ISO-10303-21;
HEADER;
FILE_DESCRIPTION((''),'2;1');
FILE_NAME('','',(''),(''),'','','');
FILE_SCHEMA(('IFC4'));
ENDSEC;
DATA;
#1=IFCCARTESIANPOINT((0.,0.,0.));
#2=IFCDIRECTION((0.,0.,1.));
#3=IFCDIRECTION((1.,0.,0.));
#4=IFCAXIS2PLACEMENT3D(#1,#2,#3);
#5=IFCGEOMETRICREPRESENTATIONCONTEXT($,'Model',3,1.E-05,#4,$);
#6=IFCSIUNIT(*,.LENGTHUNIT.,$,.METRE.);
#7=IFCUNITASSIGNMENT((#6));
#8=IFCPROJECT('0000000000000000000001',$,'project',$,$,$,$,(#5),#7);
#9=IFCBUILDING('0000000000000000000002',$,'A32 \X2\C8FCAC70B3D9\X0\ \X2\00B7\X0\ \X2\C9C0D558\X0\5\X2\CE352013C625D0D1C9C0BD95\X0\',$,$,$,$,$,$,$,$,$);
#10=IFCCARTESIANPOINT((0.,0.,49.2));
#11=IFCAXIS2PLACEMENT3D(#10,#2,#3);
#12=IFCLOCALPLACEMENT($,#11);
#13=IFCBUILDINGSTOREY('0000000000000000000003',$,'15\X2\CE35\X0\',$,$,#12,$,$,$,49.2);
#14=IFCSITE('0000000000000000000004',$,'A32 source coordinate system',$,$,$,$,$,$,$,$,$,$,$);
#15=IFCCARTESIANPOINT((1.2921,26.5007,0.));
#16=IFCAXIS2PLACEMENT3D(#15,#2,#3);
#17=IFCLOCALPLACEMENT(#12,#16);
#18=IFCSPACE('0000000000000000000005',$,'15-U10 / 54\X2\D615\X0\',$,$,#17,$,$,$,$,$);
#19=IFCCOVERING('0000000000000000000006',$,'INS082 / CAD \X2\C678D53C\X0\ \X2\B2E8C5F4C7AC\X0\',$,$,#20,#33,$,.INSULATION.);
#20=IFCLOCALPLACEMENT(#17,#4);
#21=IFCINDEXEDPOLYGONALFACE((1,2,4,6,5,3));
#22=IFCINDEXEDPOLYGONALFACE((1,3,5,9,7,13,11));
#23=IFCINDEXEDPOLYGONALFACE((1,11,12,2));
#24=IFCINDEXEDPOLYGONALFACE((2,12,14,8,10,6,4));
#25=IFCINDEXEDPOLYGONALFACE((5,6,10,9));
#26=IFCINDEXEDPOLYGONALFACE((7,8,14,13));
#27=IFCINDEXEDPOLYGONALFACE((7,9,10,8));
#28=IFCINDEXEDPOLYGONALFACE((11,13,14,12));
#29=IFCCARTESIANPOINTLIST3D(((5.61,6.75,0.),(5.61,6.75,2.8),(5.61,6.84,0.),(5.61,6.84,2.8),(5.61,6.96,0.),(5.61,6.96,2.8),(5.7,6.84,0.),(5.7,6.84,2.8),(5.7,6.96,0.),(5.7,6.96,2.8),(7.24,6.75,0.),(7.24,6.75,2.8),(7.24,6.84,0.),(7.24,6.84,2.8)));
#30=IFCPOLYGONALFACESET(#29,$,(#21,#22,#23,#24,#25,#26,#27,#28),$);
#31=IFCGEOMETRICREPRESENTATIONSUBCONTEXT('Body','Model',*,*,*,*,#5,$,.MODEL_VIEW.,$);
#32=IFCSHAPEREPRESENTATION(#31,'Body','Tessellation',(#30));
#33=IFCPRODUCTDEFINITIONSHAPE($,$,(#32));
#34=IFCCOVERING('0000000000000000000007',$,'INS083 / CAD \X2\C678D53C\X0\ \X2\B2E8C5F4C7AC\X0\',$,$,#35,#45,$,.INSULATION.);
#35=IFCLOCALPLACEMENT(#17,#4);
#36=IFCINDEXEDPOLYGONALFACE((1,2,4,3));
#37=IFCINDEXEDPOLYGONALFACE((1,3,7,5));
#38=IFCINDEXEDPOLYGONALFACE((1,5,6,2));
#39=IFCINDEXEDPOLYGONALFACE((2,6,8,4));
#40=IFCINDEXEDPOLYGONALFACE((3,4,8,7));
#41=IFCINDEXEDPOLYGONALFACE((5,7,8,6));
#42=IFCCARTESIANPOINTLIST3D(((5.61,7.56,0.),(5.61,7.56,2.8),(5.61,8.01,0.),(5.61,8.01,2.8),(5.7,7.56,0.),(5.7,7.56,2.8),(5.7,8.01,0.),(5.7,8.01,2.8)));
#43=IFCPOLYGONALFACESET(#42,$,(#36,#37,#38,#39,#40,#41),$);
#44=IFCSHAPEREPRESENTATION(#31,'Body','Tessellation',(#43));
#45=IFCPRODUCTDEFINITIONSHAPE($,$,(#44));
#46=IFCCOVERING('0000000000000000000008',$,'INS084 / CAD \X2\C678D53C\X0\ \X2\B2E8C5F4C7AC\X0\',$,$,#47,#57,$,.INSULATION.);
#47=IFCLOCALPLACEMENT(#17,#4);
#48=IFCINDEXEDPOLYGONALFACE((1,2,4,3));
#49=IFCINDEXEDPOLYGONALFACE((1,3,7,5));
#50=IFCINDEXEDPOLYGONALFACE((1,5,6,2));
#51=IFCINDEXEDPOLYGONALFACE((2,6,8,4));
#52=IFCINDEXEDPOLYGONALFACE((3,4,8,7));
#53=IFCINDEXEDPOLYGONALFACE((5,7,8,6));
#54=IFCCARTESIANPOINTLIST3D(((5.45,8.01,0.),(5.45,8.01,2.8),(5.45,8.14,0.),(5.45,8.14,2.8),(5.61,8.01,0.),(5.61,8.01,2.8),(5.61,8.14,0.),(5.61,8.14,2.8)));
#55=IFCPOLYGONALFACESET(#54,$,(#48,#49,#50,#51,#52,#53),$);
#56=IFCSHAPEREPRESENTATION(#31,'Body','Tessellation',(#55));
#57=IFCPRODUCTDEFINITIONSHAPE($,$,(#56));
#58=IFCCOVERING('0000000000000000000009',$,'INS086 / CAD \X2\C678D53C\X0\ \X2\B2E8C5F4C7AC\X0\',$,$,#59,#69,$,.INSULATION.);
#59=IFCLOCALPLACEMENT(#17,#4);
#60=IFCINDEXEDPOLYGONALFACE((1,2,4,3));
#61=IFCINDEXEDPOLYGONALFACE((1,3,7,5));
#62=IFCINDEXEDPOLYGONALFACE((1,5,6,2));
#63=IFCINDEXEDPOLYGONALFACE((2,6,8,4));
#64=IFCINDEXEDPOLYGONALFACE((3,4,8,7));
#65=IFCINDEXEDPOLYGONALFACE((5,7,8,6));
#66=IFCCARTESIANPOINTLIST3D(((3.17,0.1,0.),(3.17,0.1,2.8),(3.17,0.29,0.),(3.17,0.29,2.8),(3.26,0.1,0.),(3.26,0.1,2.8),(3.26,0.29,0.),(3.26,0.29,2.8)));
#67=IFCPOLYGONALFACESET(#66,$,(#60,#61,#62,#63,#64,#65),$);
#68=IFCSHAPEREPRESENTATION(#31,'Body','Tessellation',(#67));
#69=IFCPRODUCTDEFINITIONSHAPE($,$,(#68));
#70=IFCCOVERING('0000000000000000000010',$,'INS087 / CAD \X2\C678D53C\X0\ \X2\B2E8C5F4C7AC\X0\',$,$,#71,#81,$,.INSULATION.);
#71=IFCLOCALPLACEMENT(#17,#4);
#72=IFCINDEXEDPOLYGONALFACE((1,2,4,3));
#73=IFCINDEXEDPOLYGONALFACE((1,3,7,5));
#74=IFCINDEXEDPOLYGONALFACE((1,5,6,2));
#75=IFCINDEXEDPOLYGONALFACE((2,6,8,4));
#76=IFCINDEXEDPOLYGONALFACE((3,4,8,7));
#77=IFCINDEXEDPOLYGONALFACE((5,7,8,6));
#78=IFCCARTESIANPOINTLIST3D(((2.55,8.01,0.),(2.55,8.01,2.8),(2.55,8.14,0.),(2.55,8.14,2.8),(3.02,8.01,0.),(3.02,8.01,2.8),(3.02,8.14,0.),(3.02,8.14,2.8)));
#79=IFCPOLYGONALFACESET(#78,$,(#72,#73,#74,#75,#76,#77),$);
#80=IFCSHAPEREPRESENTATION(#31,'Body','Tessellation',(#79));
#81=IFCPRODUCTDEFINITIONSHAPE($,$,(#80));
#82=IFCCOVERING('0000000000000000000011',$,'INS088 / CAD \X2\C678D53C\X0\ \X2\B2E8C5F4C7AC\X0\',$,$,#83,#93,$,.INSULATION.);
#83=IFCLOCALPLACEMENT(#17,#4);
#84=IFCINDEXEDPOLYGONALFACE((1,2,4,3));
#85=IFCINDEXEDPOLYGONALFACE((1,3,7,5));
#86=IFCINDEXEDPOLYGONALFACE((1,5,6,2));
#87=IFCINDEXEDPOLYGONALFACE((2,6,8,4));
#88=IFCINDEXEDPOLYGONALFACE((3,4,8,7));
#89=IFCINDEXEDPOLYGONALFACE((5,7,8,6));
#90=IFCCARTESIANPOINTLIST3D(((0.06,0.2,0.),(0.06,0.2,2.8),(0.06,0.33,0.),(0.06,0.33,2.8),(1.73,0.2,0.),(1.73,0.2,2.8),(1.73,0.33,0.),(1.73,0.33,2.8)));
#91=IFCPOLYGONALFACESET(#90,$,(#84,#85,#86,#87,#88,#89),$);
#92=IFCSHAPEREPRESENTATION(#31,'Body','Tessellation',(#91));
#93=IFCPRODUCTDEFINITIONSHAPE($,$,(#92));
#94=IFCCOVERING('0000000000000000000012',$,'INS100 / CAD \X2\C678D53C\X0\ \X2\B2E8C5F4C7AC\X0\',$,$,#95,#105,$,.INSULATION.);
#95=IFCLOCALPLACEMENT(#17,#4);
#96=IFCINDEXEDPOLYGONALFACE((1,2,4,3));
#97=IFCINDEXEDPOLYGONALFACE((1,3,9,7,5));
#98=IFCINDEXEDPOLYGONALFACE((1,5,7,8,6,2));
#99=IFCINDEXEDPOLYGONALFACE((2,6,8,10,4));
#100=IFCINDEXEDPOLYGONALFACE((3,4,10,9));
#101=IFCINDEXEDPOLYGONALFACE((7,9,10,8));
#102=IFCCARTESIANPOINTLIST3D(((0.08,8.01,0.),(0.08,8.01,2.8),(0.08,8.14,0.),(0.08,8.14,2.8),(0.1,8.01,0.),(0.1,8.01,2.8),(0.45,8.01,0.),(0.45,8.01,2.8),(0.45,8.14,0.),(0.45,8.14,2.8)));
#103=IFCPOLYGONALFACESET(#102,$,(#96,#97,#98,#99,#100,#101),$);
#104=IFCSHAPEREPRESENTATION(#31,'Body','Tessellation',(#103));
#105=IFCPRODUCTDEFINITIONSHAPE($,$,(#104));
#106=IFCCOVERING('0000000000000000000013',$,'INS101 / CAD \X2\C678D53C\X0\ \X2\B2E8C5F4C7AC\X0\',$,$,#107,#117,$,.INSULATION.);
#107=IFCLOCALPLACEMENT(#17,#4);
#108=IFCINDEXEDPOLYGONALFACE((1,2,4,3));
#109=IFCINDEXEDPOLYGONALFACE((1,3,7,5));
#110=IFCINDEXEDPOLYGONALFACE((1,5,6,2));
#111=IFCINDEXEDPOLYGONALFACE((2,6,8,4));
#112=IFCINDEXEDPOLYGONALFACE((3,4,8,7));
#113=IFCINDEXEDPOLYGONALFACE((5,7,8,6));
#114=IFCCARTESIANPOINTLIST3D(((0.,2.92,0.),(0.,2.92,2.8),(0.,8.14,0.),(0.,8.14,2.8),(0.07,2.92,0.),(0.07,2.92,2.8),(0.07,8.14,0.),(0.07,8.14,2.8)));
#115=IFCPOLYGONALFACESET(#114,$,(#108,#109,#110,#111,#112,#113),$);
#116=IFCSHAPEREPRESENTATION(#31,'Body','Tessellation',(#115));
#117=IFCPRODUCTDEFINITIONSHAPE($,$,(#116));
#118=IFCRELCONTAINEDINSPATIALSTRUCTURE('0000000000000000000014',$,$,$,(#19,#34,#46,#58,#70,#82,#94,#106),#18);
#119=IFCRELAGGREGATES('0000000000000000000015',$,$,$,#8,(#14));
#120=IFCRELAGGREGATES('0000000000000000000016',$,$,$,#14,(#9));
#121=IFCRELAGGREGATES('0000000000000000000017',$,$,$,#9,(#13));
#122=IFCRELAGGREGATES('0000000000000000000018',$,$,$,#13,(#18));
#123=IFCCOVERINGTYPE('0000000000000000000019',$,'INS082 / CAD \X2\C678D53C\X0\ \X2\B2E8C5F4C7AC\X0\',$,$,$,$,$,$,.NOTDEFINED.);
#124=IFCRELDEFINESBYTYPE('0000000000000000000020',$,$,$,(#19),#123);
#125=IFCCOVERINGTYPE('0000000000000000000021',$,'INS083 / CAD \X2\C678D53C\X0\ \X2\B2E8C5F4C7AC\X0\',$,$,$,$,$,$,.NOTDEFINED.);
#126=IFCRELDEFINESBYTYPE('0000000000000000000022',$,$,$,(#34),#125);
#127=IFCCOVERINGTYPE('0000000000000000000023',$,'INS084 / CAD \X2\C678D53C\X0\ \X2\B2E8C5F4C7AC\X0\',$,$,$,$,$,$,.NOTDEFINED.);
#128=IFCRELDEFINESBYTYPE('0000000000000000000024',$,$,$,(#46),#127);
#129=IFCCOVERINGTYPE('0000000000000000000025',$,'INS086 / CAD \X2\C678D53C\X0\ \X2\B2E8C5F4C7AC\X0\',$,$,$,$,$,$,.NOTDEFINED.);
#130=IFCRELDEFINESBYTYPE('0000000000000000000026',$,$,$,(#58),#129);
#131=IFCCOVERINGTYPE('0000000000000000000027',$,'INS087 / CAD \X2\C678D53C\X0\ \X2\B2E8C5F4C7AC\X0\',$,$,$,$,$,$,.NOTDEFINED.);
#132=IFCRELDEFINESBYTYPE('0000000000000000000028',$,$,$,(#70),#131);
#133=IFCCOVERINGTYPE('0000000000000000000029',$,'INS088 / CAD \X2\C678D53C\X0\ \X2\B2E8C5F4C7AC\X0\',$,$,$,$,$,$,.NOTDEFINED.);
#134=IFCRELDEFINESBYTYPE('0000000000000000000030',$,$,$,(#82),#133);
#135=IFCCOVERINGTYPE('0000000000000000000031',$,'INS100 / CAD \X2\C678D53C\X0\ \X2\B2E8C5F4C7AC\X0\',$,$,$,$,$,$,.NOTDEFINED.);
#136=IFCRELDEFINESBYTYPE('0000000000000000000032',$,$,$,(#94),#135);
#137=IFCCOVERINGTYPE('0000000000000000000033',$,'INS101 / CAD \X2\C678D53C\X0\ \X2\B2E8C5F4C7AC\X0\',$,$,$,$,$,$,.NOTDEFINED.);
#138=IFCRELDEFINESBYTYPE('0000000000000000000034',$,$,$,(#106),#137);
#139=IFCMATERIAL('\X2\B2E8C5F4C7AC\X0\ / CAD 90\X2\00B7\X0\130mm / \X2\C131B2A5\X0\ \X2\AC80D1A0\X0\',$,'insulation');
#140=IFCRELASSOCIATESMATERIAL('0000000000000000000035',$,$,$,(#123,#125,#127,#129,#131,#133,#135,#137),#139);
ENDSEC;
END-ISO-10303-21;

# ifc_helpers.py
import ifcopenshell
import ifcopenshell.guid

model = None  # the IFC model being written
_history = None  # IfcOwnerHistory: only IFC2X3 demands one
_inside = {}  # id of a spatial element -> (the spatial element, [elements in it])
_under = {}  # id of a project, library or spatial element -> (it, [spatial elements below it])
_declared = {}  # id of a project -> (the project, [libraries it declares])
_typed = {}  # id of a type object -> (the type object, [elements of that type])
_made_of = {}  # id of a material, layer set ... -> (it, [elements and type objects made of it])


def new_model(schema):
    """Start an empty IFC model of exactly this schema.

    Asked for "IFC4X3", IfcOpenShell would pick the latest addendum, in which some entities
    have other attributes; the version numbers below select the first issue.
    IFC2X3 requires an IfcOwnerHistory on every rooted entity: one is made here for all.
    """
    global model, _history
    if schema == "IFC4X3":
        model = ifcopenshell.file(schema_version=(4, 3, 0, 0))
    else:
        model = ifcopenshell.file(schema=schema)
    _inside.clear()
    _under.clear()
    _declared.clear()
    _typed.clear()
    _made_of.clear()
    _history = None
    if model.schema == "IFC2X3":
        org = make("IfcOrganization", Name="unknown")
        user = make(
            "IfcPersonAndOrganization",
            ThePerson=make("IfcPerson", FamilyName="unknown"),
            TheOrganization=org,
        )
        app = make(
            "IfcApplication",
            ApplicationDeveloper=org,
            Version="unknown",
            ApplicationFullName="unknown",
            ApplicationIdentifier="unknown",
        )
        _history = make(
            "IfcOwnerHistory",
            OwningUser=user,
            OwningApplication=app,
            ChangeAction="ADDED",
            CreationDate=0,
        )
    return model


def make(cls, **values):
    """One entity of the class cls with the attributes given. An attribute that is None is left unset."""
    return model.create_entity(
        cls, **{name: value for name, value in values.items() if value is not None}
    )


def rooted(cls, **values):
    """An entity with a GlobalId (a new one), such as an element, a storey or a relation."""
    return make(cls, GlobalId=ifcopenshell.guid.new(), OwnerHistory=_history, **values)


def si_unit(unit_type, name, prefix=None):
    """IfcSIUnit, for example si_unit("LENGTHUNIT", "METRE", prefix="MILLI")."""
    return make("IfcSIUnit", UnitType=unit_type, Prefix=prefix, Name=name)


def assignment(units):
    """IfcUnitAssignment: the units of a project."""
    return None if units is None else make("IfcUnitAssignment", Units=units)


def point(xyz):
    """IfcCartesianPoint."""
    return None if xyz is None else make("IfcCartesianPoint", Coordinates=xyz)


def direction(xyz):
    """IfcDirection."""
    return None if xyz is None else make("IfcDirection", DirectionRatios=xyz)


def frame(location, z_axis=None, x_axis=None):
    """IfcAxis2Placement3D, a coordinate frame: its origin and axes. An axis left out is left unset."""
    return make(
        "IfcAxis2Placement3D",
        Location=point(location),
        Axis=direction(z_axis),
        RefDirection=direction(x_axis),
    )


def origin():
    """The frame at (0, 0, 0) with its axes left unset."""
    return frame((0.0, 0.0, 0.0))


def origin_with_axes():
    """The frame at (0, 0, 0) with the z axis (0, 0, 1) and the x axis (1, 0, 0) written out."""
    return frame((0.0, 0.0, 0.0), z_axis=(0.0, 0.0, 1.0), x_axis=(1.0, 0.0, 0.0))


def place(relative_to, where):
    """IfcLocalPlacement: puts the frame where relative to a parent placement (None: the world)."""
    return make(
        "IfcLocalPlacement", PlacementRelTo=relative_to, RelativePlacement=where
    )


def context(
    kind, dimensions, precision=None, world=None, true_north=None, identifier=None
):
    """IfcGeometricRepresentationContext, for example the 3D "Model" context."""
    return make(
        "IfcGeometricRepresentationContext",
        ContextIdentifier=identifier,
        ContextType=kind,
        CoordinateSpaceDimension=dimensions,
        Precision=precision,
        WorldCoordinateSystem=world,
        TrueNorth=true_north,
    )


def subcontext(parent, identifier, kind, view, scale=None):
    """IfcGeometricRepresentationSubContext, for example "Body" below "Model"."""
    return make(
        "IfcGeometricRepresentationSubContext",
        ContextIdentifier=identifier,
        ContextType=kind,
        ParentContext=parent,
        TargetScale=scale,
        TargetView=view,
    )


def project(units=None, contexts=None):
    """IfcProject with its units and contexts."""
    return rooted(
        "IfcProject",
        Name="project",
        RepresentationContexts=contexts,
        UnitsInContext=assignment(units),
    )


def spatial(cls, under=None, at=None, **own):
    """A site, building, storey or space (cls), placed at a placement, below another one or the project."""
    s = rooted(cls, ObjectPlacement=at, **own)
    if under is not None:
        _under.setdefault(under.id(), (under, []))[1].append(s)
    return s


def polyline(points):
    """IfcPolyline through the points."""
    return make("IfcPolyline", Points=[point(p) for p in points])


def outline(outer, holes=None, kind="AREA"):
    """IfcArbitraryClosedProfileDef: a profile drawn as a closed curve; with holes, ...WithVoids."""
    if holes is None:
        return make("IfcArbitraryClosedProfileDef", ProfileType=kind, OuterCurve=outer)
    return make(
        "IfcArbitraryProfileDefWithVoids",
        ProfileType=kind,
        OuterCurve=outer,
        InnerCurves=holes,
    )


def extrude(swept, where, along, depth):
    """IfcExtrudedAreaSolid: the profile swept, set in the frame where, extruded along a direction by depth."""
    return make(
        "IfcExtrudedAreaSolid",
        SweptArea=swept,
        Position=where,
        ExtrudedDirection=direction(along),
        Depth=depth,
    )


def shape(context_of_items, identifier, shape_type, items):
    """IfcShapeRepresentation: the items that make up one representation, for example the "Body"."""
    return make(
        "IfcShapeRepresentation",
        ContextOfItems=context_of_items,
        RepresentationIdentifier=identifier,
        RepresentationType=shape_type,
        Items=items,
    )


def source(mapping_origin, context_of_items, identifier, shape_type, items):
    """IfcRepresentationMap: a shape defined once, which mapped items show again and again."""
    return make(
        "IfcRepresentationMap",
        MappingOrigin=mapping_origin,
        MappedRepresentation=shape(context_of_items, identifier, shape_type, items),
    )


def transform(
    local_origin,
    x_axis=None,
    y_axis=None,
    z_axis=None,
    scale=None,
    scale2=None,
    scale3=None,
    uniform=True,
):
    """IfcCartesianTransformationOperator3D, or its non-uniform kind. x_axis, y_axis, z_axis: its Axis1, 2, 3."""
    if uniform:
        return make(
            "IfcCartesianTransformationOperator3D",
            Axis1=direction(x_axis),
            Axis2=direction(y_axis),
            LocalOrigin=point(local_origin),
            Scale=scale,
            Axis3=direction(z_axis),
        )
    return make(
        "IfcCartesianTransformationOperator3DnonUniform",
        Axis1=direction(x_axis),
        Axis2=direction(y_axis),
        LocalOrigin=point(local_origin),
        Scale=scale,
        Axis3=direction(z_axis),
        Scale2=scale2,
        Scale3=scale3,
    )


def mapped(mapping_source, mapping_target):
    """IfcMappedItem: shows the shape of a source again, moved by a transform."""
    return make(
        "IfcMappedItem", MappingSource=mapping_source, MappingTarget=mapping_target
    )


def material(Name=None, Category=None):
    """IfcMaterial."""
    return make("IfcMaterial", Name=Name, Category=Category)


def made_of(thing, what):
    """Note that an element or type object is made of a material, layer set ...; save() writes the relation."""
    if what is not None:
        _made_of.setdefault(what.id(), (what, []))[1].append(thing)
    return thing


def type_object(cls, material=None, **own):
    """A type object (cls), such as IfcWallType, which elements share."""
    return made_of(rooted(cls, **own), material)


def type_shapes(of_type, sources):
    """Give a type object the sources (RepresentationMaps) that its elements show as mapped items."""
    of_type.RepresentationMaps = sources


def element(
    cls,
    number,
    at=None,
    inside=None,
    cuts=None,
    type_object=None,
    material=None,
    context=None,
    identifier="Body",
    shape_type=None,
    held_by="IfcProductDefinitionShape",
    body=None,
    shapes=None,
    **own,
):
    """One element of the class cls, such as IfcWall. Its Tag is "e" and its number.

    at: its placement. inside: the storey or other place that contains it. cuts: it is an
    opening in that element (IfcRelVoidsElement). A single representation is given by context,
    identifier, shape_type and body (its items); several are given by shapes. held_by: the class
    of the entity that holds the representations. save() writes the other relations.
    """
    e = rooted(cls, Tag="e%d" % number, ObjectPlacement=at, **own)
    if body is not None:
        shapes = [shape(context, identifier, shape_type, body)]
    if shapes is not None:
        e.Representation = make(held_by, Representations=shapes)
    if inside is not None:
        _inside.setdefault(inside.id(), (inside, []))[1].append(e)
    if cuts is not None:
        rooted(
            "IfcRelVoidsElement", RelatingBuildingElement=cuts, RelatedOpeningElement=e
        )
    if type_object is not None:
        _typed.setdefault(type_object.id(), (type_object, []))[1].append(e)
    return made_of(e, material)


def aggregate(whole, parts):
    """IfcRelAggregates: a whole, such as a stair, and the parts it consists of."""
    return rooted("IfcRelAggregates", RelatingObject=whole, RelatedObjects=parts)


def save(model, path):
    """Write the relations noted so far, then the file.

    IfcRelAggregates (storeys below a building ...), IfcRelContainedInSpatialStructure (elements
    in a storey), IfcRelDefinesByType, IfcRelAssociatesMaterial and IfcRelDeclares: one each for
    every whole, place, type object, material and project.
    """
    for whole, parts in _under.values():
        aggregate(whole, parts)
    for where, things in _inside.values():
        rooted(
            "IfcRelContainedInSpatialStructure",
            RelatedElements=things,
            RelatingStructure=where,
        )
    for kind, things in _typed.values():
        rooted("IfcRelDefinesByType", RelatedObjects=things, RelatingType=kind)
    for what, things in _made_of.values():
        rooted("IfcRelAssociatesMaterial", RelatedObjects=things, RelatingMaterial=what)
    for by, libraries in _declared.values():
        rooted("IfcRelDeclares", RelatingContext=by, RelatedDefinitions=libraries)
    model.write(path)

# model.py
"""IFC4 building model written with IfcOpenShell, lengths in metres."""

from ifc_helpers import new_model, si_unit, frame, origin, origin_with_axes, place, context, subcontext, project, spatial, polyline, outline, extrude, source, transform, mapped, material, type_object, type_shapes, element, save


model = new_model("IFC4")

# Units and contexts
model_context = context("Model", 3, precision=1e-05, world=origin_with_axes())
body_context = subcontext(model_context, "Body", "Model", "MODEL_VIEW")
ifc_project = project(units=[si_unit("LENGTHUNIT", "METRE")], contexts=[model_context])

# Site, building, storey, space
storey_placement = place(None, frame((0.0, 0.0, 49.2), z_axis=(0.0, 0.0, 1.0), x_axis=(1.0, 0.0, 0.0)))
space_placement = place(storey_placement, frame((1.2921, 26.5007, 0.0), z_axis=(0.0, 0.0, 1.0), x_axis=(1.0, 0.0, 0.0)))
site = spatial("IfcSite", under=ifc_project, Name="A32 source coordinate system")
building = spatial("IfcBuilding", under=site, Name="A32 주거동 · 지하5층–옥탑지붕")
storey = spatial("IfcBuildingStorey", under=building, at=storey_placement, Name="15층", Elevation=49.2)
space = spatial("IfcSpace", under=storey, at=space_placement, Name="15-U10 / 54형")

# Coverings
ifc_material = material(Name="단열재 / CAD 90·130mm / 성능 검토", Category="insulation")
covering_type_1 = type_object("IfcCoveringType", Name="INS082 / CAD 외피 단열재", PredefinedType="NOTDEFINED", material=ifc_material)
shared_shape_1 = source(origin(), body_context, "Body", "SweptSolid", [
    extrude(outline(polyline([(5.61, 6.84), (5.61, 6.96), (5.7, 6.96), (5.7, 6.84), (7.24, 6.84), (7.24, 6.75), (5.61, 6.75), (5.61, 6.84)])), origin(), (0.0, 0.0, 1.0), 2.8),
])
type_shapes(covering_type_1, [shared_shape_1])
covering_1_placement = place(space_placement, origin_with_axes())
element("IfcCovering", 1, at=covering_1_placement, inside=space, type_object=covering_type_1, Name="INS082 / CAD 외피 단열재", PredefinedType="INSULATION", context=body_context, shape_type="MappedRepresentation", body=[
    mapped(shared_shape_1, transform((0.0, 0.0, 0.0), scale=1.0)),
])
covering_type_2 = type_object("IfcCoveringType", Name="INS083 / CAD 외피 단열재", PredefinedType="NOTDEFINED", material=ifc_material)
shared_shape_2 = source(origin(), body_context, "Body", "SweptSolid", [
    extrude(outline(polyline([(5.61, 8.01), (5.7, 8.01), (5.7, 7.56), (5.61, 7.56), (5.61, 8.01)])), origin(), (0.0, 0.0, 1.0), 2.8),
])
type_shapes(covering_type_2, [shared_shape_2])
covering_2_placement = place(space_placement, origin_with_axes())
element("IfcCovering", 2, at=covering_2_placement, inside=space, type_object=covering_type_2, Name="INS083 / CAD 외피 단열재", PredefinedType="INSULATION", context=body_context, shape_type="MappedRepresentation", body=[
    mapped(shared_shape_2, transform((0.0, 0.0, 0.0), scale=1.0)),
])
covering_type_3 = type_object("IfcCoveringType", Name="INS084 / CAD 외피 단열재", PredefinedType="NOTDEFINED", material=ifc_material)
shared_shape_3 = source(origin(), body_context, "Body", "SweptSolid", [
    extrude(outline(polyline([(5.45, 8.01), (5.45, 8.14), (5.61, 8.14), (5.61, 8.01), (5.45, 8.01)])), origin(), (0.0, 0.0, 1.0), 2.8),
])
type_shapes(covering_type_3, [shared_shape_3])
covering_3_placement = place(space_placement, origin_with_axes())
element("IfcCovering", 3, at=covering_3_placement, inside=space, type_object=covering_type_3, Name="INS084 / CAD 외피 단열재", PredefinedType="INSULATION", context=body_context, shape_type="MappedRepresentation", body=[
    mapped(shared_shape_3, transform((0.0, 0.0, 0.0), scale=1.0)),
])
covering_type_4 = type_object("IfcCoveringType", Name="INS086 / CAD 외피 단열재", PredefinedType="NOTDEFINED", material=ifc_material)
shared_shape_4 = source(origin(), body_context, "Body", "SweptSolid", [
    extrude(outline(polyline([(3.17, 0.1), (3.17, 0.29), (3.26, 0.29), (3.26, 0.1), (3.17, 0.1)])), origin(), (0.0, 0.0, 1.0), 2.8),
])
type_shapes(covering_type_4, [shared_shape_4])
covering_4_placement = place(space_placement, origin_with_axes())
element("IfcCovering", 4, at=covering_4_placement, inside=space, type_object=covering_type_4, Name="INS086 / CAD 외피 단열재", PredefinedType="INSULATION", context=body_context, shape_type="MappedRepresentation", body=[
    mapped(shared_shape_4, transform((0.0, 0.0, 0.0), scale=1.0)),
])
covering_type_5 = type_object("IfcCoveringType", Name="INS087 / CAD 외피 단열재", PredefinedType="NOTDEFINED", material=ifc_material)
shared_shape_5 = source(origin(), body_context, "Body", "SweptSolid", [
    extrude(outline(polyline([(2.55, 8.14), (3.02, 8.14), (3.02, 8.01), (2.55, 8.01), (2.55, 8.14)])), origin(), (0.0, 0.0, 1.0), 2.8),
])
type_shapes(covering_type_5, [shared_shape_5])
covering_5_placement = place(space_placement, origin_with_axes())
element("IfcCovering", 5, at=covering_5_placement, inside=space, type_object=covering_type_5, Name="INS087 / CAD 외피 단열재", PredefinedType="INSULATION", context=body_context, shape_type="MappedRepresentation", body=[
    mapped(shared_shape_5, transform((0.0, 0.0, 0.0), scale=1.0)),
])
covering_type_6 = type_object("IfcCoveringType", Name="INS088 / CAD 외피 단열재", PredefinedType="NOTDEFINED", material=ifc_material)
shared_shape_6 = source(origin(), body_context, "Body", "SweptSolid", [
    extrude(outline(polyline([(0.06, 0.33), (1.73, 0.33), (1.73, 0.2), (0.06, 0.2), (0.06, 0.33)])), origin(), (0.0, 0.0, 1.0), 2.8),
])
type_shapes(covering_type_6, [shared_shape_6])
covering_6_placement = place(space_placement, origin_with_axes())
element("IfcCovering", 6, at=covering_6_placement, inside=space, type_object=covering_type_6, Name="INS088 / CAD 외피 단열재", PredefinedType="INSULATION", context=body_context, shape_type="MappedRepresentation", body=[
    mapped(shared_shape_6, transform((0.0, 0.0, 0.0), scale=1.0)),
])
covering_type_7 = type_object("IfcCoveringType", Name="INS100 / CAD 외피 단열재", PredefinedType="NOTDEFINED", material=ifc_material)
shared_shape_7 = source(origin(), body_context, "Body", "SweptSolid", [
    extrude(outline(polyline([(0.08, 8.01), (0.08, 8.14), (0.45, 8.14), (0.45, 8.01), (0.1, 8.01), (0.08, 8.01)])), origin(), (0.0, 0.0, 1.0), 2.8),
])
type_shapes(covering_type_7, [shared_shape_7])
covering_7_placement = place(space_placement, origin_with_axes())
element("IfcCovering", 7, at=covering_7_placement, inside=space, type_object=covering_type_7, Name="INS100 / CAD 외피 단열재", PredefinedType="INSULATION", context=body_context, shape_type="MappedRepresentation", body=[
    mapped(shared_shape_7, transform((0.0, 0.0, 0.0), scale=1.0)),
])
covering_type_8 = type_object("IfcCoveringType", Name="INS101 / CAD 외피 단열재", PredefinedType="NOTDEFINED", material=ifc_material)
shared_shape_8 = source(origin(), body_context, "Body", "SweptSolid", [
    extrude(outline(polyline([(0.0, 2.92), (0.0, 8.14), (0.07, 8.14), (0.07, 2.92), (0.0, 2.92)])), origin(), (0.0, 0.0, 1.0), 2.8),
])
type_shapes(covering_type_8, [shared_shape_8])
covering_8_placement = place(space_placement, origin_with_axes())
element("IfcCovering", 8, at=covering_8_placement, inside=space, type_object=covering_type_8, Name="INS101 / CAD 외피 단열재", PredefinedType="INSULATION", context=body_context, shape_type="MappedRepresentation", body=[
    mapped(shared_shape_8, transform((0.0, 0.0, 0.0), scale=1.0)),
])

save(model, "model.ifc")
